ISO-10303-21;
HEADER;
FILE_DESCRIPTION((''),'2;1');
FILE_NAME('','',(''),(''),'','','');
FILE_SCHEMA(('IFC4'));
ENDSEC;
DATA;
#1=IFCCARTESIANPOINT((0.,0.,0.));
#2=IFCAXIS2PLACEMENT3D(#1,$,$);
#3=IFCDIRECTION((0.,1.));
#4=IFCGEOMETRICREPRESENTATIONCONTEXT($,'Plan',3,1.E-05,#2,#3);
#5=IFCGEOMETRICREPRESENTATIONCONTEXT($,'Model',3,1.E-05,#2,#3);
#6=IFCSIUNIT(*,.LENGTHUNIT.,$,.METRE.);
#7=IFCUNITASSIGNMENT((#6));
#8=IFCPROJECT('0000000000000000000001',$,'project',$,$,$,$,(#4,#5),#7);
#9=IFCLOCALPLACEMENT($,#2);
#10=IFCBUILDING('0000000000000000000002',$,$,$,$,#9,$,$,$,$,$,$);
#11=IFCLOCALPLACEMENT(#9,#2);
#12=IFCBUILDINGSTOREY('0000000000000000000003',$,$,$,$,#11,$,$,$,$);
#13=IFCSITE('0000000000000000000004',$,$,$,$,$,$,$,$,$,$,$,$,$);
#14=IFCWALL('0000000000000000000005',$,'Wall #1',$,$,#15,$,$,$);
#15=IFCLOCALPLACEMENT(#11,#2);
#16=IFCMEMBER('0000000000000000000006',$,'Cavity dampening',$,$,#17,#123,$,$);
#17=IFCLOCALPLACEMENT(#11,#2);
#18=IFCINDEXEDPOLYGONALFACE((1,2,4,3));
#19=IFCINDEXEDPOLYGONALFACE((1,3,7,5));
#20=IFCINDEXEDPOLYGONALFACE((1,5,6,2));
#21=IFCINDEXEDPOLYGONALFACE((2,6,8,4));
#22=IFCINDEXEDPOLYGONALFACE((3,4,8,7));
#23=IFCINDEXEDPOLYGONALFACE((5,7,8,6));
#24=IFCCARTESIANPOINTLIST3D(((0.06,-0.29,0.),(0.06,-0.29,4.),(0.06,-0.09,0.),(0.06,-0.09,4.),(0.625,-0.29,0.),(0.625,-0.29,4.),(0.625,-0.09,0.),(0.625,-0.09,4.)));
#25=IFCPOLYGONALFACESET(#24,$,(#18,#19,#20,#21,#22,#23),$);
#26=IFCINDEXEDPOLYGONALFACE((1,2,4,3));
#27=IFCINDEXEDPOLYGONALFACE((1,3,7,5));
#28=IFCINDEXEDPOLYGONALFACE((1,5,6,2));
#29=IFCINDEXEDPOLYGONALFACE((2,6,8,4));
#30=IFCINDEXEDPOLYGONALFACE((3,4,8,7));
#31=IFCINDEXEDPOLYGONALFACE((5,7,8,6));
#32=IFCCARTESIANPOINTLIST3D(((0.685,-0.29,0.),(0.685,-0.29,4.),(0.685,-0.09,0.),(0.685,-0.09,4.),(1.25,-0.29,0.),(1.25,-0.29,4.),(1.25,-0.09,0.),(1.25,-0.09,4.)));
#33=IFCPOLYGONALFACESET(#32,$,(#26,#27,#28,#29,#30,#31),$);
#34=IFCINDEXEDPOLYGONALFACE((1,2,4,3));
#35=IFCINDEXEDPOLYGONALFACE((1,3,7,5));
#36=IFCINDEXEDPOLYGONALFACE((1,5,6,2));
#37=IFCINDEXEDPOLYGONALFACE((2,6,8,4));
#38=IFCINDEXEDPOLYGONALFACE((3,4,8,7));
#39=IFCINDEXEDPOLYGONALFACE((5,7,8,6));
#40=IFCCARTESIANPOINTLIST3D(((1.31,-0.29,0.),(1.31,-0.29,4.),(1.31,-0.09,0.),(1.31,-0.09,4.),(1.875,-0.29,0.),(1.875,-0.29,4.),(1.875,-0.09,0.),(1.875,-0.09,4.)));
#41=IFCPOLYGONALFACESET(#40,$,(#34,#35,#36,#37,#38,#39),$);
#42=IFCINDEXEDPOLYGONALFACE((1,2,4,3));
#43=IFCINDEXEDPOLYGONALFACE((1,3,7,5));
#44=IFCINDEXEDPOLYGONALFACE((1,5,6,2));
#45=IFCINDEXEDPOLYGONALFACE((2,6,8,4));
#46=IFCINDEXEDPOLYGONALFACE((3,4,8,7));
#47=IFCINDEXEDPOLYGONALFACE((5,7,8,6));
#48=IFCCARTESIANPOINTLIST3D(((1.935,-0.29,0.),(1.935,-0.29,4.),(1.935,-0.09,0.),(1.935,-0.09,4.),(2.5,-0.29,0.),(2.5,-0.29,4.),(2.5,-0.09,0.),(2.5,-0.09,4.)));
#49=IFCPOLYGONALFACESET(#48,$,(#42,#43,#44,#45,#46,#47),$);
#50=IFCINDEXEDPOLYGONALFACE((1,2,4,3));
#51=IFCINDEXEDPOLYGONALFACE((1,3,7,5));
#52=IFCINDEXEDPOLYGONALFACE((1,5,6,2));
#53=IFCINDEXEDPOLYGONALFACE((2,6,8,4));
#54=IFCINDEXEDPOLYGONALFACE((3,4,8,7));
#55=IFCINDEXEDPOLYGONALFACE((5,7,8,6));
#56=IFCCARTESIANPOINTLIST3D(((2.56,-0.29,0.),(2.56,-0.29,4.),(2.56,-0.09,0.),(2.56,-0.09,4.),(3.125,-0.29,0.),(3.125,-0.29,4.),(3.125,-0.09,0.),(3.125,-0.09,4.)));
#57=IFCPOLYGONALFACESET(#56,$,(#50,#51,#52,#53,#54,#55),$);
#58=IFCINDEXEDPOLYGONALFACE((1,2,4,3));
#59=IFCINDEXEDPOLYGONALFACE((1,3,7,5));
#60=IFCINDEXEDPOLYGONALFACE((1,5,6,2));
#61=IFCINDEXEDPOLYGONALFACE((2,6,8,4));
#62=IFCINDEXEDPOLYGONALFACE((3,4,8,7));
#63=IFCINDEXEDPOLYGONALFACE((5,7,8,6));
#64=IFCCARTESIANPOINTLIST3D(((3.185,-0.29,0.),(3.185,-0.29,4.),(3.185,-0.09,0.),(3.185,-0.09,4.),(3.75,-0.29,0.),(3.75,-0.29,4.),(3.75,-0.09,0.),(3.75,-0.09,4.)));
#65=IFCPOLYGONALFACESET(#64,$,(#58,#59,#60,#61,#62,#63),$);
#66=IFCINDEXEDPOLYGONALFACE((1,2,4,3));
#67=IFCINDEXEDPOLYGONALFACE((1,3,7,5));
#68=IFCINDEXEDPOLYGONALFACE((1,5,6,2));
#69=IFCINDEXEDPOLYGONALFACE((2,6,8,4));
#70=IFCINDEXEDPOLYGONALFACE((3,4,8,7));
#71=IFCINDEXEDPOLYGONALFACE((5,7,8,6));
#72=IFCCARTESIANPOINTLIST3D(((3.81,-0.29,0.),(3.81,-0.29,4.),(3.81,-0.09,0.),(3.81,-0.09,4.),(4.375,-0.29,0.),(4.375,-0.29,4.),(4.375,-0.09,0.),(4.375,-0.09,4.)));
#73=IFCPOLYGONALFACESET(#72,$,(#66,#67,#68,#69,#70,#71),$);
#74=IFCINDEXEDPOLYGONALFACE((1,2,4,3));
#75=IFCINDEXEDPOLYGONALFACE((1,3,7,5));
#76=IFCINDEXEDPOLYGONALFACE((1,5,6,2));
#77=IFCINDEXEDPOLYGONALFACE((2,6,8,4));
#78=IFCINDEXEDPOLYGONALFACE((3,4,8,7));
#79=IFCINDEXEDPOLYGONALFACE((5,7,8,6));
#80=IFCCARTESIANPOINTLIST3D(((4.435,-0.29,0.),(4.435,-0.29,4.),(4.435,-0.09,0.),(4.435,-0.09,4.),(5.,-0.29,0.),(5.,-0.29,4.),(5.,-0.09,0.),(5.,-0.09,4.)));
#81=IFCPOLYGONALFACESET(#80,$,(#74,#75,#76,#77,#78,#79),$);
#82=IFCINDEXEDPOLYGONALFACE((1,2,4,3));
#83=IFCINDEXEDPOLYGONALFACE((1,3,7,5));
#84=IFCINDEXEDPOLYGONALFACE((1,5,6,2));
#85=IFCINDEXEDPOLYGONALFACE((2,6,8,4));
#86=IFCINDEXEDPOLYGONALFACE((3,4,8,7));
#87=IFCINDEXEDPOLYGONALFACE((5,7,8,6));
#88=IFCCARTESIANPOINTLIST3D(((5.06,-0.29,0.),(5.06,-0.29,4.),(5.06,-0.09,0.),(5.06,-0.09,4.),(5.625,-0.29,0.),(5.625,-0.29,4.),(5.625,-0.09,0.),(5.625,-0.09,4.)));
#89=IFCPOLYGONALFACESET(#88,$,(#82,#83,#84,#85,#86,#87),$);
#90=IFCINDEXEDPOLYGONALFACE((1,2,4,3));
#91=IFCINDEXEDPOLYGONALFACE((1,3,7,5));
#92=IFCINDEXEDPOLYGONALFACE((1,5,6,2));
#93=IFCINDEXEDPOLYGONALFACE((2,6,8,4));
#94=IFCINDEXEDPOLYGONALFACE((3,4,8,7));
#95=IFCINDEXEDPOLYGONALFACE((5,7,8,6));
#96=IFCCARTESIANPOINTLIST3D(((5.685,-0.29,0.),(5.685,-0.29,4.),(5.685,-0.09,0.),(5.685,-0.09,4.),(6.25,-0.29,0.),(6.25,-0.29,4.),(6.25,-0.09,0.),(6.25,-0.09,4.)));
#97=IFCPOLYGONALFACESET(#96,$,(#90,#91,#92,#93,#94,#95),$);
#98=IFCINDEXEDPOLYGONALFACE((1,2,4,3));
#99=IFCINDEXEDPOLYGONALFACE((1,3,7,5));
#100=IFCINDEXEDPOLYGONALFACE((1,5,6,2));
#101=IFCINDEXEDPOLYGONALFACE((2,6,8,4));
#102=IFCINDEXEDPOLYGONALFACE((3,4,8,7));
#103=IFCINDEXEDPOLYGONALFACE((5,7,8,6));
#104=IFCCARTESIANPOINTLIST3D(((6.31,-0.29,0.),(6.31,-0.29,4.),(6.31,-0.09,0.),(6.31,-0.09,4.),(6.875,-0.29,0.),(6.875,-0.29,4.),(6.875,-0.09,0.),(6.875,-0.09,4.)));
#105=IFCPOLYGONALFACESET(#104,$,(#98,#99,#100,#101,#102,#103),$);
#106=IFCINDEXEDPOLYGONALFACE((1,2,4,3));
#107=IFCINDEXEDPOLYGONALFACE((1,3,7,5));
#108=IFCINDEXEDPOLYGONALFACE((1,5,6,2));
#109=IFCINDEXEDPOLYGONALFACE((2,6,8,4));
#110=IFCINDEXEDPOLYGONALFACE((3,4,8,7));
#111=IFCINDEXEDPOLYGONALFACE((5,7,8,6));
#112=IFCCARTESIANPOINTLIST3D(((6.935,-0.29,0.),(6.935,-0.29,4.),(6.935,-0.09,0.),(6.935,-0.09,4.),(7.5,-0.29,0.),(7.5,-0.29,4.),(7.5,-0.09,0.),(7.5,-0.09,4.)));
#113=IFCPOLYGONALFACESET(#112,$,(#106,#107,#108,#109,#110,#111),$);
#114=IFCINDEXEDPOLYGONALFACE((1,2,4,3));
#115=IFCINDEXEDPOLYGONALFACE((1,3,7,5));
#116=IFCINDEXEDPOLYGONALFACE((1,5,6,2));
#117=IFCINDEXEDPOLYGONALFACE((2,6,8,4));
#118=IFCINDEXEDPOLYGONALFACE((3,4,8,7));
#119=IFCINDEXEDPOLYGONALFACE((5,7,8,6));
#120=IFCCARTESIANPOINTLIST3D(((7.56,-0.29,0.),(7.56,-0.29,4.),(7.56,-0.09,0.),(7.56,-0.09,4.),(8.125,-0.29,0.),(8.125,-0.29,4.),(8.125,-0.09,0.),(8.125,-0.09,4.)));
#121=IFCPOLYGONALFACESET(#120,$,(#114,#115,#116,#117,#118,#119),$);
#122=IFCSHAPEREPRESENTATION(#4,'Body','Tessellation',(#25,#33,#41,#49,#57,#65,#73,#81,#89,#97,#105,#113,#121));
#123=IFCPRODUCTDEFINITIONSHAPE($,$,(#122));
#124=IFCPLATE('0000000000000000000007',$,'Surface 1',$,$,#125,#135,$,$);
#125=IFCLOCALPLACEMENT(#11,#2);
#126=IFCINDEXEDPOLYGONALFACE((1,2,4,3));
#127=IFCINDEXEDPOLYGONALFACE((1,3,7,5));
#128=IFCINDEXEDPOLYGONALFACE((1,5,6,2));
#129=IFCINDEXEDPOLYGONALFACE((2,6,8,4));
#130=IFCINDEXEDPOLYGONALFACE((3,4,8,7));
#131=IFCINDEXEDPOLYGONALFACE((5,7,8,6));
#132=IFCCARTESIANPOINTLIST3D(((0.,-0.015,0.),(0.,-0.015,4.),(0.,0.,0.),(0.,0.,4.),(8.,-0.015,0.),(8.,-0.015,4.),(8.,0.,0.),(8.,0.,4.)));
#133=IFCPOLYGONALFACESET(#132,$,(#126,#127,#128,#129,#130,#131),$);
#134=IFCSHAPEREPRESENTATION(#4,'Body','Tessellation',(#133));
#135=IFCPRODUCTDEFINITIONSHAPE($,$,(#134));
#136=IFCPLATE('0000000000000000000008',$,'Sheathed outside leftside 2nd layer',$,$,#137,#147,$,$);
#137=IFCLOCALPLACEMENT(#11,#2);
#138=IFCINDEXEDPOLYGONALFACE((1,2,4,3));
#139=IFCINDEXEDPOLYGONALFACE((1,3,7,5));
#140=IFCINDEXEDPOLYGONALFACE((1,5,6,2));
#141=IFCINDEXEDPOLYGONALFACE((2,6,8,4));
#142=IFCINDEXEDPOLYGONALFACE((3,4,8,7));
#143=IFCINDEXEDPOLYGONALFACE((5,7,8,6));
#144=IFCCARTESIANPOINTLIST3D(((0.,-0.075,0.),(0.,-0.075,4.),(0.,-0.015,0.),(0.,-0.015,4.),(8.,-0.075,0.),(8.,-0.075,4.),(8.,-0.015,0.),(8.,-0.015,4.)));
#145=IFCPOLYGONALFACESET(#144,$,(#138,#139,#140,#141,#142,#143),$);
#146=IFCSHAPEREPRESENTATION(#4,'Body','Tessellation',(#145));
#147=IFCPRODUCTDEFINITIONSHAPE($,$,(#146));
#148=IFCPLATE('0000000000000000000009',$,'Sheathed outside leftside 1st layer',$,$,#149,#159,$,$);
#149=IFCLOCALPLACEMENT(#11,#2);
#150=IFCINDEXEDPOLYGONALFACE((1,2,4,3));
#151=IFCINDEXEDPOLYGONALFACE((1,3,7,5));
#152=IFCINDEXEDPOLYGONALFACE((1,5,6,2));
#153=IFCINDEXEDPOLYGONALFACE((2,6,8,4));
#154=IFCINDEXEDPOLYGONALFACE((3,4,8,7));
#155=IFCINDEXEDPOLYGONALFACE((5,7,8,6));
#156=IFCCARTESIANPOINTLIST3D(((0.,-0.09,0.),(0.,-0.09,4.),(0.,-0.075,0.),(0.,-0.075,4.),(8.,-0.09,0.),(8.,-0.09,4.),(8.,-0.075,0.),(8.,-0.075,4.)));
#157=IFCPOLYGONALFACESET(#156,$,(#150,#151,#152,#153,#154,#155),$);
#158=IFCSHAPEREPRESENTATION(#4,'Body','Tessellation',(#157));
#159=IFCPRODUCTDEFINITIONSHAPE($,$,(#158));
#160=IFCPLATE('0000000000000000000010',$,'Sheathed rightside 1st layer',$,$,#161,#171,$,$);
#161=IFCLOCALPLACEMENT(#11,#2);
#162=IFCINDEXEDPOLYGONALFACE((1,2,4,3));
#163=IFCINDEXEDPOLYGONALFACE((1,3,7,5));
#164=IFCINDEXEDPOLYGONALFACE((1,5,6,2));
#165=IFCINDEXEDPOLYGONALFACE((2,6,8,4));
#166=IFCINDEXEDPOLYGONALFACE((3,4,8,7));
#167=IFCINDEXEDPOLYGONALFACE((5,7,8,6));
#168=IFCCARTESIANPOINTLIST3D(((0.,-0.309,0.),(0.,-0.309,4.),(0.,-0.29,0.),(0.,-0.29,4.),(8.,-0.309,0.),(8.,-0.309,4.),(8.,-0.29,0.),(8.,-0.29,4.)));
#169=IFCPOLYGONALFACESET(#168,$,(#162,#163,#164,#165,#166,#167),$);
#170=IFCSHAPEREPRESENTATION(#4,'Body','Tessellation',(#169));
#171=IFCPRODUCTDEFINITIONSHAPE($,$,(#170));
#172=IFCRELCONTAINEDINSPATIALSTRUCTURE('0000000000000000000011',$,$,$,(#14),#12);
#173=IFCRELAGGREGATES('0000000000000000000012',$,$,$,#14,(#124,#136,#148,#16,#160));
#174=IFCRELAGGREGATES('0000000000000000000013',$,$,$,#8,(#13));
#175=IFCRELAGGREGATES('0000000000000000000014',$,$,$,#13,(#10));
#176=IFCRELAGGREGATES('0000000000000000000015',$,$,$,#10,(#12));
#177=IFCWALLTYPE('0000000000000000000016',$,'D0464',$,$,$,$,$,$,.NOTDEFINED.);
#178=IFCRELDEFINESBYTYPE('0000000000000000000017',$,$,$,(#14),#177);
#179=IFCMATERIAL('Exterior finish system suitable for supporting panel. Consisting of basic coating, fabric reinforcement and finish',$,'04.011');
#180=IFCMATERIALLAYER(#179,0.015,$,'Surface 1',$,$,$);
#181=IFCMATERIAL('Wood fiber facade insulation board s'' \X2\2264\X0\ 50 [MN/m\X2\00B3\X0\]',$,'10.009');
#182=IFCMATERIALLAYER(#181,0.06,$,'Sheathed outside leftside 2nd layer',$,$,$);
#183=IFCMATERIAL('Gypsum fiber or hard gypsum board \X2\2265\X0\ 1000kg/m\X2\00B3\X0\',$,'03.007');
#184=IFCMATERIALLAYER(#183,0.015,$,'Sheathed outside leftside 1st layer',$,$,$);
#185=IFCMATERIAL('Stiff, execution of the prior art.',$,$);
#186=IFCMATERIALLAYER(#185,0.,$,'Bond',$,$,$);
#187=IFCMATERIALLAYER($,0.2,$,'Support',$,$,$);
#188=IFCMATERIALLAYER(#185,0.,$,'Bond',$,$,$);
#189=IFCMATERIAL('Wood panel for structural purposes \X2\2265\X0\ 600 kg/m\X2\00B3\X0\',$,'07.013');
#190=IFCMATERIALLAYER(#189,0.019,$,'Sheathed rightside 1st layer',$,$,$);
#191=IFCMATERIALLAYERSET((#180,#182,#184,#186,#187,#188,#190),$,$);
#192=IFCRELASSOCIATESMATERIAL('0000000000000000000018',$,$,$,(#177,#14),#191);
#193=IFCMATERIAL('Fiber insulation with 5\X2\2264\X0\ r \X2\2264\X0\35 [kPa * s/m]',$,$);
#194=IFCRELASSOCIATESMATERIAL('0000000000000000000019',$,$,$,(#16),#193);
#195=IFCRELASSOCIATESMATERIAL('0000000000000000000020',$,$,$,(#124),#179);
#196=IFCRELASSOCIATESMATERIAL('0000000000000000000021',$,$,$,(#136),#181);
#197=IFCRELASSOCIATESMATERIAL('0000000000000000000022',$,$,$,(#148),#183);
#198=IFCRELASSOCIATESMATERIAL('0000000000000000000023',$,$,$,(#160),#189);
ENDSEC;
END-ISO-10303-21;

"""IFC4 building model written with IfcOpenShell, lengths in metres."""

from ifc_helpers import new_model, si_unit, direction, frame, frame_2d, origin, origin_with_axes, place, context, project, spatial, rectangle, extrude, material, layer, layer_set, type_object, element, aggregate, save


model = new_model("IFC4")

# Units and contexts
plan_context = context("Plan", 3, precision=1e-05, world=origin(), true_north=direction((0.0, 1.0)))
model_context = context("Model", 3, precision=1e-05, world=origin(), true_north=direction((0.0, 1.0)))
ifc_project = project(units=[si_unit("LENGTHUNIT", "METRE")], contexts=[plan_context, model_context])

# Site, building, storey
site = spatial("IfcSite", under=ifc_project)
building_placement = place(None, origin())
building = spatial("IfcBuilding", under=site, at=building_placement)
storey_placement = place(building_placement, origin())
storey = spatial("IfcBuildingStorey", under=building, at=storey_placement)

# Wall, member, plates
ifc_material_1 = material(Name="Exterior finish system suitable for supporting panel. Consisting of basic coating, fabric reinforcement and finish", Category="04.011")
ifc_layer_1 = layer(ifc_material_1, 0.015, Name="Surface 1")
ifc_material_2 = material(Name="Wood fiber facade insulation board s' ≤ 50 [MN/m³]", Category="10.009")
ifc_layer_2 = layer(ifc_material_2, 0.06, Name="Sheathed outside leftside 2nd layer")
ifc_material_3 = material(Name="Gypsum fiber or hard gypsum board ≥ 1000kg/m³", Category="03.007")
ifc_layer_3 = layer(ifc_material_3, 0.015, Name="Sheathed outside leftside 1st layer")
ifc_material_4 = material(Name="Stiff, execution of the prior art.")
ifc_layer_4 = layer(ifc_material_4, 0.0, Name="Bond")
ifc_layer_5 = layer(None, 0.2, Name="Support")
ifc_layer_6 = layer(ifc_material_4, 0.0, Name="Bond")
ifc_material_5 = material(Name="Wood panel for structural purposes ≥ 600 kg/m³", Category="07.013")
ifc_layer_7 = layer(ifc_material_5, 0.019, Name="Sheathed rightside 1st layer")
ifc_layer_set = layer_set([ifc_layer_1, ifc_layer_2, ifc_layer_3, ifc_layer_4, ifc_layer_5, ifc_layer_6, ifc_layer_7])
wall_type = type_object("IfcWallType", Name="D0464", PredefinedType="NOTDEFINED", material=ifc_layer_set)
wall_placement = place(None, frame((0.0, 0.0, 0.0), z_axis=(0.0, -1.0, 0.0), x_axis=(1.0, 0.0, 0.0)))
wall = element("IfcWall", 1, at=wall_placement, inside=storey, type_object=wall_type, material=ifc_layer_set, Name="Wall #1")
ifc_material_6 = material(Name="Fiber insulation with 5≤ r ≤35 [kPa * s/m]")
member_1_placement = place(wall_placement, origin())
member_1 = element("IfcMember", 2, at=member_1_placement, material=ifc_material_6, Name="Cavity dampening", context=plan_context, shape_type="SweptSolid", body=[
    extrude(rectangle(XDim=0.565, YDim=0.2, at=frame_2d((0.2825, 0.1), x_axis=(1.0, 0.0))), frame((0.06, 4.0, 0.09), z_axis=(0.0, -1.0, 0.0), x_axis=(1.0, 0.0, 0.0)), (0.0, 0.0, 1.0), 4.0),
    extrude(rectangle(XDim=0.565, YDim=0.2, at=frame_2d((0.2825, 0.1), x_axis=(1.0, 0.0))), frame((0.685, 4.0, 0.09), z_axis=(0.0, -1.0, 0.0), x_axis=(1.0, 0.0, 0.0)), (0.0, 0.0, 1.0), 4.0),
    extrude(rectangle(XDim=0.565, YDim=0.2, at=frame_2d((0.2825, 0.1), x_axis=(1.0, 0.0))), frame((1.31, 4.0, 0.09), z_axis=(0.0, -1.0, 0.0), x_axis=(1.0, 0.0, 0.0)), (0.0, 0.0, 1.0), 4.0),
    extrude(rectangle(XDim=0.565, YDim=0.2, at=frame_2d((0.2825, 0.1), x_axis=(1.0, 0.0))), frame((1.935, 4.0, 0.09), z_axis=(0.0, -1.0, 0.0), x_axis=(1.0, 0.0, 0.0)), (0.0, 0.0, 1.0), 4.0),
    extrude(rectangle(XDim=0.565, YDim=0.2, at=frame_2d((0.2825, 0.1), x_axis=(1.0, 0.0))), frame((2.56, 4.0, 0.09), z_axis=(0.0, -1.0, 0.0), x_axis=(1.0, 0.0, 0.0)), (0.0, 0.0, 1.0), 4.0),
    extrude(rectangle(XDim=0.565, YDim=0.2, at=frame_2d((0.2825, 0.1), x_axis=(1.0, 0.0))), frame((3.185, 4.0, 0.09), z_axis=(0.0, -1.0, 0.0), x_axis=(1.0, 0.0, 0.0)), (0.0, 0.0, 1.0), 4.0),
    extrude(rectangle(XDim=0.565, YDim=0.2, at=frame_2d((0.2825, 0.1), x_axis=(1.0, 0.0))), frame((3.81, 4.0, 0.09), z_axis=(0.0, -1.0, 0.0), x_axis=(1.0, 0.0, 0.0)), (0.0, 0.0, 1.0), 4.0),
    extrude(rectangle(XDim=0.565, YDim=0.2, at=frame_2d((0.2825, 0.1), x_axis=(1.0, 0.0))), frame((4.435, 4.0, 0.09), z_axis=(0.0, -1.0, 0.0), x_axis=(1.0, 0.0, 0.0)), (0.0, 0.0, 1.0), 4.0),
    extrude(rectangle(XDim=0.565, YDim=0.2, at=frame_2d((0.2825, 0.1), x_axis=(1.0, 0.0))), frame((5.06, 4.0, 0.09), z_axis=(0.0, -1.0, 0.0), x_axis=(1.0, 0.0, 0.0)), (0.0, 0.0, 1.0), 4.0),
    extrude(rectangle(XDim=0.565, YDim=0.2, at=frame_2d((0.2825, 0.1), x_axis=(1.0, 0.0))), frame((5.685, 4.0, 0.09), z_axis=(0.0, -1.0, 0.0), x_axis=(1.0, 0.0, 0.0)), (0.0, 0.0, 1.0), 4.0),
    extrude(rectangle(XDim=0.565, YDim=0.2, at=frame_2d((0.2825, 0.1), x_axis=(1.0, 0.0))), frame((6.31, 4.0, 0.09), z_axis=(0.0, -1.0, 0.0), x_axis=(1.0, 0.0, 0.0)), (0.0, 0.0, 1.0), 4.0),
    extrude(rectangle(XDim=0.565, YDim=0.2, at=frame_2d((0.2825, 0.1), x_axis=(1.0, 0.0))), frame((6.935, 4.0, 0.09), z_axis=(0.0, -1.0, 0.0), x_axis=(1.0, 0.0, 0.0)), (0.0, 0.0, 1.0), 4.0),
    extrude(rectangle(XDim=0.565, YDim=0.2, at=frame_2d((0.2825, 0.1), x_axis=(1.0, 0.0))), frame((7.56, 4.0, 0.09), z_axis=(0.0, -1.0, 0.0), x_axis=(1.0, 0.0, 0.0)), (0.0, 0.0, 1.0), 4.0),
])
plate_1_placement = place(wall_placement, origin())
plate_1 = element("IfcPlate", 3, at=plate_1_placement, material=ifc_material_1, Name="Surface 1", context=plan_context, shape_type="SweptSolid", body=[
    extrude(rectangle(XDim=8.0, YDim=4.0, at=frame_2d((4.0, 2.0), x_axis=(1.0, 0.0))), origin_with_axes(), (0.0, 0.0, 1.0), 0.015),
])
plate_2_placement = place(wall_placement, origin())
plate_2 = element("IfcPlate", 4, at=plate_2_placement, material=ifc_material_2, Name="Sheathed outside leftside 2nd layer", context=plan_context, shape_type="SweptSolid", body=[
    extrude(rectangle(XDim=8.0, YDim=4.0, at=frame_2d((4.0, 2.0), x_axis=(1.0, 0.0))), frame((0.0, 0.0, 0.015), z_axis=(0.0, 0.0, 1.0), x_axis=(1.0, 0.0, 0.0)), (0.0, 0.0, 1.0), 0.06),
])
plate_3_placement = place(wall_placement, origin())
plate_3 = element("IfcPlate", 5, at=plate_3_placement, material=ifc_material_3, Name="Sheathed outside leftside 1st layer", context=plan_context, shape_type="SweptSolid", body=[
    extrude(rectangle(XDim=8.0, YDim=4.0, at=frame_2d((4.0, 2.0), x_axis=(1.0, 0.0))), frame((0.0, 0.0, 0.075), z_axis=(0.0, 0.0, 1.0), x_axis=(1.0, 0.0, 0.0)), (0.0, 0.0, 1.0), 0.015),
])
plate_4_placement = place(wall_placement, origin())
plate_4 = element("IfcPlate", 6, at=plate_4_placement, material=ifc_material_5, Name="Sheathed rightside 1st layer", context=plan_context, shape_type="SweptSolid", body=[
    extrude(rectangle(XDim=8.0, YDim=4.0, at=frame_2d((4.0, 2.0), x_axis=(1.0, 0.0))), frame((0.0, 0.0, 0.29), z_axis=(0.0, 0.0, 1.0), x_axis=(1.0, 0.0, 0.0)), (0.0, 0.0, 1.0), 0.019),
])
aggregate(wall, [plate_1, plate_2, plate_3, member_1, plate_4])

save(model, "model.ifc")
